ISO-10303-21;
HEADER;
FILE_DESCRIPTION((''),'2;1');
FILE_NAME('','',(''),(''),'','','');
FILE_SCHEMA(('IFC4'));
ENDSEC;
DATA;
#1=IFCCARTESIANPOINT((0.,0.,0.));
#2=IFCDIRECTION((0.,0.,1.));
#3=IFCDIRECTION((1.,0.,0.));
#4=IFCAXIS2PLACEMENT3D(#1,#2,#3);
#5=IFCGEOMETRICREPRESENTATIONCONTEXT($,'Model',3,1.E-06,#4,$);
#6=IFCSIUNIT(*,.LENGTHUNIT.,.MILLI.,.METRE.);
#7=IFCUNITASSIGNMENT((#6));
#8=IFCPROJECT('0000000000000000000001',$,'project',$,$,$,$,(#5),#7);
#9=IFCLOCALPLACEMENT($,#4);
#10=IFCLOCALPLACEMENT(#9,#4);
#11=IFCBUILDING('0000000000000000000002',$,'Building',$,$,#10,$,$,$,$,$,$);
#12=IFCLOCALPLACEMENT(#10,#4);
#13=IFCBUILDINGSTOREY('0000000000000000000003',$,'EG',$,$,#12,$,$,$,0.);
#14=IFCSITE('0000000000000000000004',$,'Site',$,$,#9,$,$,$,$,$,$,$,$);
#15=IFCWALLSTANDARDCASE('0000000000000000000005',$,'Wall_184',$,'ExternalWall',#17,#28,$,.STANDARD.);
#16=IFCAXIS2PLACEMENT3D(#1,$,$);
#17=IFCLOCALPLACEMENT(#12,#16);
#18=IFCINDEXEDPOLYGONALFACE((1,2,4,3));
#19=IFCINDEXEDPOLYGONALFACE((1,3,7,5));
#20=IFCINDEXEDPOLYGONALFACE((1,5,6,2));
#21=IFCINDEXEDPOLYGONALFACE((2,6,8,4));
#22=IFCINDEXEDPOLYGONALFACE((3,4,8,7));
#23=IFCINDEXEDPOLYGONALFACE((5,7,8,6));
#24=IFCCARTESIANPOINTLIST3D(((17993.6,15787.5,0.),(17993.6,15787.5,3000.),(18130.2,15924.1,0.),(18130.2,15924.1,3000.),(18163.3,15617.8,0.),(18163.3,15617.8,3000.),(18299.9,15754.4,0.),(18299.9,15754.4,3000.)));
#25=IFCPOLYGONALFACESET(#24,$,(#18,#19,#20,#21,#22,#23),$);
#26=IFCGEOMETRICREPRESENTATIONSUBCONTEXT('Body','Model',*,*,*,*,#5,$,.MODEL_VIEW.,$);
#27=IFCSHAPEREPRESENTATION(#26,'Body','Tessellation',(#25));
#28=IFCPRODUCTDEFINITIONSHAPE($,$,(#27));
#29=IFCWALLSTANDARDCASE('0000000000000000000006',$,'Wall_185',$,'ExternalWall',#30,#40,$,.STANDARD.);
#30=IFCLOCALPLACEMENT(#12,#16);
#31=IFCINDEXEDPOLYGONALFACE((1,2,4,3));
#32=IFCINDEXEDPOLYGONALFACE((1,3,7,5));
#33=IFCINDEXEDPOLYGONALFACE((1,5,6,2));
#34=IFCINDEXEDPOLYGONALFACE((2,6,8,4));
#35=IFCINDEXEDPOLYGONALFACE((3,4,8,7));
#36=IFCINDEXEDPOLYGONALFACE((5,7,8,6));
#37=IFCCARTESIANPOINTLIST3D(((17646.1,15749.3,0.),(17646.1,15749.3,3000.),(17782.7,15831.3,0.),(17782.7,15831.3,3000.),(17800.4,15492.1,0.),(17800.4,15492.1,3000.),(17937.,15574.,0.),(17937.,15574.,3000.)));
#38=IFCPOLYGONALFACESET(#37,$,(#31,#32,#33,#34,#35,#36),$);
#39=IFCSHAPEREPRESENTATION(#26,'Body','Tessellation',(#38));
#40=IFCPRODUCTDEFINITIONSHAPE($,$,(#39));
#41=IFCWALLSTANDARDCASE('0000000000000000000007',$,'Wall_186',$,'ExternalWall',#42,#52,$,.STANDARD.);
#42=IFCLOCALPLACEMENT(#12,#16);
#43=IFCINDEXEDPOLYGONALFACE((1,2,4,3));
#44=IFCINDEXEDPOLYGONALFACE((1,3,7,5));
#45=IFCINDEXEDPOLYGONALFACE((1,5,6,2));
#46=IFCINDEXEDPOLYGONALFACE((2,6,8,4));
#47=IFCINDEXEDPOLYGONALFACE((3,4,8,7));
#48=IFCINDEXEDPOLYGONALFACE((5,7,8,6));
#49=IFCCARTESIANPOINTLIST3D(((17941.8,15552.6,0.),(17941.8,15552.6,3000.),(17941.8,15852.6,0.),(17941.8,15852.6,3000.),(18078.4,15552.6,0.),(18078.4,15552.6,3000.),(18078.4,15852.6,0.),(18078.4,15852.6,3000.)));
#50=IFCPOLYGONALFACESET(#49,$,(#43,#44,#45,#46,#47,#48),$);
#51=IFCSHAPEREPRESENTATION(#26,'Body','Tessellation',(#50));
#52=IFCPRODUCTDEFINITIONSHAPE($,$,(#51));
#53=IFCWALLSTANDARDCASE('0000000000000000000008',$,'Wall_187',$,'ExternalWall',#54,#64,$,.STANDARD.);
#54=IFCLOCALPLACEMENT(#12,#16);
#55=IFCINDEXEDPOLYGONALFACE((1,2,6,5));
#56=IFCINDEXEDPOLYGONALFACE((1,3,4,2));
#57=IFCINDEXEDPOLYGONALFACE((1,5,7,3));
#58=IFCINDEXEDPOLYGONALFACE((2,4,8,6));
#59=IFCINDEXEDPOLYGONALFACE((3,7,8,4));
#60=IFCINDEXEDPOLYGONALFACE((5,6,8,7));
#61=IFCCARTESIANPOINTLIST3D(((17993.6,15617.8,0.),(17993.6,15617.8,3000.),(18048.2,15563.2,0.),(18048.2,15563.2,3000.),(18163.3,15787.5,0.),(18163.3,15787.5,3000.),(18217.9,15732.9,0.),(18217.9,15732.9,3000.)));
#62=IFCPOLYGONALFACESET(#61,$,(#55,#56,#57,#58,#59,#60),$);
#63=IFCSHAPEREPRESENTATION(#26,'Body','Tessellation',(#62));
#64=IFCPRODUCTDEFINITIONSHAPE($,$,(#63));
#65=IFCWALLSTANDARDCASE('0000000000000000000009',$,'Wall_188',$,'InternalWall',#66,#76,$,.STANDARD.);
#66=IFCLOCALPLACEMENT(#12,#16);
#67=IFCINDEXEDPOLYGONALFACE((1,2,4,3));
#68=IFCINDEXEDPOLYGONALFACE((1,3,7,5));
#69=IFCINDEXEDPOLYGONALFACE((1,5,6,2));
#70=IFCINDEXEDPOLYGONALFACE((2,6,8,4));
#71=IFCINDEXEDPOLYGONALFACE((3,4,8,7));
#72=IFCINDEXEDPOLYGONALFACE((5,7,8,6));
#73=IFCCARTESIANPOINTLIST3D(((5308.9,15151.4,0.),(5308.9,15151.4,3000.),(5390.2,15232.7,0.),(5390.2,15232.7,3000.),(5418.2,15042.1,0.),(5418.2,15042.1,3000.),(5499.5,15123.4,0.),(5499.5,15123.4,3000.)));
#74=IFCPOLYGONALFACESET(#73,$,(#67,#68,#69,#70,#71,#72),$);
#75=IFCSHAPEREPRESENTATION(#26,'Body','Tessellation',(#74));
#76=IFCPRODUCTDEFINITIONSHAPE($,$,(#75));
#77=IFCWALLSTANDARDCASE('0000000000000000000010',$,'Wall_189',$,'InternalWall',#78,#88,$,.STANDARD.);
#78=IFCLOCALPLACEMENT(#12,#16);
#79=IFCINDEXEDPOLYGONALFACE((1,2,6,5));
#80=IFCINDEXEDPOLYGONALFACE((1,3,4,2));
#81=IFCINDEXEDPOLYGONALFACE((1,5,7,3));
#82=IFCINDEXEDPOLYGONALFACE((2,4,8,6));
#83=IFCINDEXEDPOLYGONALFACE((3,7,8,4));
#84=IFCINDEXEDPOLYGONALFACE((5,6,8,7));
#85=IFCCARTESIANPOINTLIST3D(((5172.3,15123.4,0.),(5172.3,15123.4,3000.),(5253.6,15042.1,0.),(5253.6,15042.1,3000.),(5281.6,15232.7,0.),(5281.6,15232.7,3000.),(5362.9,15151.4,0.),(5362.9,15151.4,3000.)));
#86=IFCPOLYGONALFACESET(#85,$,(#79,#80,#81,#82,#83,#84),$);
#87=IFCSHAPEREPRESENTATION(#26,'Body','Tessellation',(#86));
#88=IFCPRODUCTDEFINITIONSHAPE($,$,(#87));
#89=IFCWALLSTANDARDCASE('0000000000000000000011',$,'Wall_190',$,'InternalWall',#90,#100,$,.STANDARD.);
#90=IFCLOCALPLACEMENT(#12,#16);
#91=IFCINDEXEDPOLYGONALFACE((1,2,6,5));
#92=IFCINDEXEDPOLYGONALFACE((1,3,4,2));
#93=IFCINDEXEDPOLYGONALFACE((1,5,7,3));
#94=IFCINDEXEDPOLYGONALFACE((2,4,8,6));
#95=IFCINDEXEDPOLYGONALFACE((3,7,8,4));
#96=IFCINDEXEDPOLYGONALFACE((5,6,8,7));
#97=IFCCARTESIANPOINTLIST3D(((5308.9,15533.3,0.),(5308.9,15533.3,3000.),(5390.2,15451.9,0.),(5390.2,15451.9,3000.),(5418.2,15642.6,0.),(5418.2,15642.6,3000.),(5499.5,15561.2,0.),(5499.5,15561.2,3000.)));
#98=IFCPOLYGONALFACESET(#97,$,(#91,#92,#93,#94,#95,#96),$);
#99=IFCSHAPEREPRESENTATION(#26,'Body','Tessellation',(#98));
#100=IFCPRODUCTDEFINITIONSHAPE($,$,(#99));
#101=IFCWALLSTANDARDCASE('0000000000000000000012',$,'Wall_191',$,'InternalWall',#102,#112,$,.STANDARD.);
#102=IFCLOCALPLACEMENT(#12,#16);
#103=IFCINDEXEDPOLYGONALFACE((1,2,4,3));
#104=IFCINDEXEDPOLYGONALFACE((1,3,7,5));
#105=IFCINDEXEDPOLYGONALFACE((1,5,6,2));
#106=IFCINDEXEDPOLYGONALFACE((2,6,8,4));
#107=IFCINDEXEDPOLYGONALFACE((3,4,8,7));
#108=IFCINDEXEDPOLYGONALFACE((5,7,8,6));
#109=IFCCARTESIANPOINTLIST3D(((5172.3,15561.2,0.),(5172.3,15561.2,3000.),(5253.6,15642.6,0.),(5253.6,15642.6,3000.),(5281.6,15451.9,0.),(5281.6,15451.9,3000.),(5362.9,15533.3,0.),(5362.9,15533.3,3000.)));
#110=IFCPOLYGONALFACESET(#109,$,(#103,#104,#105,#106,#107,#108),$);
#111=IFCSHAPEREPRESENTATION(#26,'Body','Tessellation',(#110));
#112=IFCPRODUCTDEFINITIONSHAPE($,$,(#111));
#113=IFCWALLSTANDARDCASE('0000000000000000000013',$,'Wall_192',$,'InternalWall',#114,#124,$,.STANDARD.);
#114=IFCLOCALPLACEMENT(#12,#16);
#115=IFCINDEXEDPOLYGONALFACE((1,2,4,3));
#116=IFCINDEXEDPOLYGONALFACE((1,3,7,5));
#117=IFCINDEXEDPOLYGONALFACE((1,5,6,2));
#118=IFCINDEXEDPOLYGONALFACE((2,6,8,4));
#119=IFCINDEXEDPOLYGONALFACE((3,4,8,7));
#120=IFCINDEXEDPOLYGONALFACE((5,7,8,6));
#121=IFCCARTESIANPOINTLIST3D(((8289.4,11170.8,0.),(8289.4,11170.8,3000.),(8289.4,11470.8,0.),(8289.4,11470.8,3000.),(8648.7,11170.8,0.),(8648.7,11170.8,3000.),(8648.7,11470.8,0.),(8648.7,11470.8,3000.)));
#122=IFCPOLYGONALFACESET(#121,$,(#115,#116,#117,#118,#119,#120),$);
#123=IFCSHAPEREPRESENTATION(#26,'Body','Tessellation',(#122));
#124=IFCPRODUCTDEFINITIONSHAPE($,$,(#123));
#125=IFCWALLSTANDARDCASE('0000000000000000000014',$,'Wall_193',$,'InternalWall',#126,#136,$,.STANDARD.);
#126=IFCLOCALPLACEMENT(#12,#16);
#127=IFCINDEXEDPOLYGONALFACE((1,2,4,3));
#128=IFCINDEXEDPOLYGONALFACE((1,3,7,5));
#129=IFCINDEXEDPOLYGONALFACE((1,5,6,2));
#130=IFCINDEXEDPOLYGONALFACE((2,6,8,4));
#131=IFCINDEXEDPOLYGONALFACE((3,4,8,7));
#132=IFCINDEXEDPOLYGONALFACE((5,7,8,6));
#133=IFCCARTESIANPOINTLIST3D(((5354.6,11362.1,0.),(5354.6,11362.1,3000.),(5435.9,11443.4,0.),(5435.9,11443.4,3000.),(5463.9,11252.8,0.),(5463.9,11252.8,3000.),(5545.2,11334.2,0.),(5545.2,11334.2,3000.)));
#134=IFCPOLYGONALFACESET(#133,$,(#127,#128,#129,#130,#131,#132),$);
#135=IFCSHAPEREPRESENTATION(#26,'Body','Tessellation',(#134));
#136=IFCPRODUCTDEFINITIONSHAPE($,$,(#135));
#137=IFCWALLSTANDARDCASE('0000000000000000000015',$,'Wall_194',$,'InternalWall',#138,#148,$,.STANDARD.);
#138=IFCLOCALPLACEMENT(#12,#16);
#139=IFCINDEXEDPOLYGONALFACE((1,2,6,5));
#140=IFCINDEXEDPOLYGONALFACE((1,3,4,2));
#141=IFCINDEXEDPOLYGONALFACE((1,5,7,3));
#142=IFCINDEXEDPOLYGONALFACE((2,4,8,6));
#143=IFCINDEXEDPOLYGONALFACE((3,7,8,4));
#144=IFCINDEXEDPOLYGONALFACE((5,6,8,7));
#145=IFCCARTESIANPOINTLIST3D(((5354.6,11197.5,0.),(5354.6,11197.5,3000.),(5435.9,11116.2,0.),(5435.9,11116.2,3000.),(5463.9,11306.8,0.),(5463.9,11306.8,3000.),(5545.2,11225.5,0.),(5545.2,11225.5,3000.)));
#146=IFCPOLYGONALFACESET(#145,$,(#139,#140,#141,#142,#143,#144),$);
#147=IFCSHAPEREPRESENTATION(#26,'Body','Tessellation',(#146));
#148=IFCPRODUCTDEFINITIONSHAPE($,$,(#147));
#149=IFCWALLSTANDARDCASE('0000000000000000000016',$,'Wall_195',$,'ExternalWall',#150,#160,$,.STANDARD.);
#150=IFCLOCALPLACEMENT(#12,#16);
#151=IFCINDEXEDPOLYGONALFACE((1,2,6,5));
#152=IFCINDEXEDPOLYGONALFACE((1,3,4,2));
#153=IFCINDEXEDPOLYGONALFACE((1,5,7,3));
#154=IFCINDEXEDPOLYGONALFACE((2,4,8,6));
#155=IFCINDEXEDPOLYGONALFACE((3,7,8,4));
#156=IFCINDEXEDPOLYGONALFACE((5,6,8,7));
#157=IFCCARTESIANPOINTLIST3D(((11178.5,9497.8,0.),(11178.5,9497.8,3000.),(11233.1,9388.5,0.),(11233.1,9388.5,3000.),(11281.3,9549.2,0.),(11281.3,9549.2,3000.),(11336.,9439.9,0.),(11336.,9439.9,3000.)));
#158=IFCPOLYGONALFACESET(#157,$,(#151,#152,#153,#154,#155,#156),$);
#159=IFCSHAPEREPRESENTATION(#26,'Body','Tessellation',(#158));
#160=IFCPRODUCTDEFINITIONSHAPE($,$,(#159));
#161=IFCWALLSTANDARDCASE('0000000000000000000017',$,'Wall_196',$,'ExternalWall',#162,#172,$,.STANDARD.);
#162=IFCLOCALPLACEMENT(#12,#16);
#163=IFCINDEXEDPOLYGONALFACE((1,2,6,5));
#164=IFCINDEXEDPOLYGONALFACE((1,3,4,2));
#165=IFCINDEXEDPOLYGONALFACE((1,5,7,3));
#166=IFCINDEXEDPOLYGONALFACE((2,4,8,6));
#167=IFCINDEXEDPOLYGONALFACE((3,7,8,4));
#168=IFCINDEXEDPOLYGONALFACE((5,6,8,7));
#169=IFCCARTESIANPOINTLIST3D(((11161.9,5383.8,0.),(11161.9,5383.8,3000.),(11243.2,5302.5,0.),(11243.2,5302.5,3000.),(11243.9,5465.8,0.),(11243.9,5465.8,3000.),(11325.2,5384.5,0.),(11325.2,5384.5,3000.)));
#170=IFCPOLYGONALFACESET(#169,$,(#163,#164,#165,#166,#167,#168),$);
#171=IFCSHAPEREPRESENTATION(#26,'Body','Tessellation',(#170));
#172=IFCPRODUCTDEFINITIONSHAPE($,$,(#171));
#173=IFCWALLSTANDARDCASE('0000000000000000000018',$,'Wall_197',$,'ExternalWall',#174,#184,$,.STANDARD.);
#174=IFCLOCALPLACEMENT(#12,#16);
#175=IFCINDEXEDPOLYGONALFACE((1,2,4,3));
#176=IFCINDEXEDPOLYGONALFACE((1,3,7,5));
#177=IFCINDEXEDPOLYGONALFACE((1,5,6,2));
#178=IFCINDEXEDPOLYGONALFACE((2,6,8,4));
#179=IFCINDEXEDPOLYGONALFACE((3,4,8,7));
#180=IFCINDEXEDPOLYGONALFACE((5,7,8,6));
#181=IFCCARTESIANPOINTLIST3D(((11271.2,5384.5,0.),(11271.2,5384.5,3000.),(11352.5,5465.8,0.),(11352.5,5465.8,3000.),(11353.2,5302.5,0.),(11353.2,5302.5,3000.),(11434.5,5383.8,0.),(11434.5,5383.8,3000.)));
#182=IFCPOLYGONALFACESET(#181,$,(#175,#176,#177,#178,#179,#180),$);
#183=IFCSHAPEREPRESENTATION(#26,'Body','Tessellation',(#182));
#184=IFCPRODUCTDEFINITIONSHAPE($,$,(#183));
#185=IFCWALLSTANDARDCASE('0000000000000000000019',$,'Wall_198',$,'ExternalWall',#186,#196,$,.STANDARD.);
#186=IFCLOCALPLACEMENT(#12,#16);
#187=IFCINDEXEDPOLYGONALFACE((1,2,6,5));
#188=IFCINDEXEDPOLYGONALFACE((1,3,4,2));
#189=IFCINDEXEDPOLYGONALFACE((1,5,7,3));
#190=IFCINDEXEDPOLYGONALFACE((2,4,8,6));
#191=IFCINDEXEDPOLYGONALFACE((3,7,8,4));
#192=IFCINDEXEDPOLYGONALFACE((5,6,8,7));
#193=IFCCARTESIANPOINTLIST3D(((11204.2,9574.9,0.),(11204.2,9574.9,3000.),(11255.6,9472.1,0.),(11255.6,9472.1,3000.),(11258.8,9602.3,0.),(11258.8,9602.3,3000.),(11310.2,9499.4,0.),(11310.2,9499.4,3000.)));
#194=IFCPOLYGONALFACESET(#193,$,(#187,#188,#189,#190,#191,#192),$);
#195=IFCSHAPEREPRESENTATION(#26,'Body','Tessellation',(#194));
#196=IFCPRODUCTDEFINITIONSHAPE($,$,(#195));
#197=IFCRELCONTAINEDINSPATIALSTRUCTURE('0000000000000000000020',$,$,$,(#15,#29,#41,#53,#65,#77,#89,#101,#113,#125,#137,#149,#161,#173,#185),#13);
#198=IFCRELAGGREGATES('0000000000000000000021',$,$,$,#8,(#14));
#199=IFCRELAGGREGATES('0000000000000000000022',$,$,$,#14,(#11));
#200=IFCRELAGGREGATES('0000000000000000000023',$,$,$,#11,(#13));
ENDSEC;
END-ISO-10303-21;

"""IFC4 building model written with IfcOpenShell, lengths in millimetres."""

from ifc_helpers import new_model, si_unit, frame, origin_with_axes, place, context, subcontext, project, spatial, rectangle, extrude, element, save


model = new_model("IFC4")

# Units and contexts
model_context = context("Model", 3, precision=1e-06, world=origin_with_axes())
body_context = subcontext(model_context, "Body", "Model", "MODEL_VIEW")
ifc_project = project(units=[si_unit("LENGTHUNIT", "METRE", prefix="MILLI")], contexts=[model_context])

# Site, building, storey
site_placement = place(None, origin_with_axes())
site = spatial("IfcSite", under=ifc_project, at=site_placement, Name="Site")
building_placement = place(site_placement, origin_with_axes())
building = spatial("IfcBuilding", under=site, at=building_placement, Name="Building")
storey_placement = place(building_placement, origin_with_axes())
storey = spatial("IfcBuildingStorey", under=building, at=storey_placement, Name="EG", Elevation=0.0)

# Walls
wall_1_placement = place(storey_placement, origin_with_axes())
element("IfcWallStandardCase", 1, at=wall_1_placement, inside=storey, Name="Wall_184", ObjectType="ExternalWall", PredefinedType="STANDARD", context=body_context, shape_type="SweptSolid", body=[
    extrude(rectangle(XDim=193.2, YDim=240.0), frame((18146.7, 15771.0, 0.0), z_axis=(0.0, 0.0, 1.0), x_axis=(0.707107, 0.707107, 0.0)), (0.0, 0.0, 1.0), 3000.0),
])
wall_2_placement = place(storey_placement, origin_with_axes())
element("IfcWallStandardCase", 2, at=wall_2_placement, inside=storey, Name="Wall_185", ObjectType="ExternalWall", PredefinedType="STANDARD", context=body_context, shape_type="SweptSolid", body=[
    extrude(rectangle(XDim=159.3, YDim=300.0), frame((17791.5, 15661.7, 0.0), z_axis=(0.0, 0.0, 1.0), x_axis=(0.857493, 0.514496, 0.0)), (0.0, 0.0, 1.0), 3000.0),
])
wall_3_placement = place(storey_placement, origin_with_axes())
element("IfcWallStandardCase", 3, at=wall_3_placement, inside=storey, Name="Wall_186", ObjectType="ExternalWall", PredefinedType="STANDARD", context=body_context, shape_type="SweptSolid", body=[
    extrude(rectangle(XDim=136.6, YDim=300.0), frame((18010.1, 15702.6, 0.0), z_axis=(0.0, 0.0, 1.0), x_axis=(1.0, 0.0, 0.0)), (0.0, 0.0, 1.0), 3000.0),
])
wall_4_placement = place(storey_placement, origin_with_axes())
element("IfcWallStandardCase", 4, at=wall_4_placement, inside=storey, Name="Wall_187", ObjectType="ExternalWall", PredefinedType="STANDARD", context=body_context, shape_type="SweptSolid", body=[
    extrude(rectangle(XDim=77.3, YDim=240.0), frame((18105.7, 15675.3, 0.0), z_axis=(0.0, 0.0, 1.0), x_axis=(0.707107, -0.707107, 0.0)), (0.0, 0.0, 1.0), 3000.0),
])
wall_5_placement = place(storey_placement, origin_with_axes())
element("IfcWallStandardCase", 5, at=wall_5_placement, inside=storey, Name="Wall_188", ObjectType="InternalWall", PredefinedType="STANDARD", context=body_context, shape_type="SweptSolid", body=[
    extrude(rectangle(XDim=154.6, YDim=115.0), frame((5404.2, 15137.4, 0.0), z_axis=(0.0, 0.0, 1.0), x_axis=(0.707107, -0.707107, 0.0)), (0.0, 0.0, 1.0), 3000.0),
])
wall_6_placement = place(storey_placement, origin_with_axes())
element("IfcWallStandardCase", 6, at=wall_6_placement, inside=storey, Name="Wall_189", ObjectType="InternalWall", PredefinedType="STANDARD", context=body_context, shape_type="SweptSolid", body=[
    extrude(rectangle(XDim=154.6, YDim=115.0), frame((5267.6, 15137.4, 0.0), z_axis=(0.0, 0.0, 1.0), x_axis=(-0.707107, -0.707107, 0.0)), (0.0, 0.0, 1.0), 3000.0),
])
wall_7_placement = place(storey_placement, origin_with_axes())
element("IfcWallStandardCase", 7, at=wall_7_placement, inside=storey, Name="Wall_190", ObjectType="InternalWall", PredefinedType="STANDARD", context=body_context, shape_type="SweptSolid", body=[
    extrude(rectangle(XDim=154.6, YDim=115.0), frame((5404.2, 15547.3, 0.0), z_axis=(0.0, 0.0, 1.0), x_axis=(0.707107, 0.707107, 0.0)), (0.0, 0.0, 1.0), 3000.0),
])
wall_8_placement = place(storey_placement, origin_with_axes())
element("IfcWallStandardCase", 8, at=wall_8_placement, inside=storey, Name="Wall_191", ObjectType="InternalWall", PredefinedType="STANDARD", context=body_context, shape_type="SweptSolid", body=[
    extrude(rectangle(XDim=154.6, YDim=115.0), frame((5267.6, 15547.3, 0.0), z_axis=(0.0, 0.0, 1.0), x_axis=(-0.707107, 0.707107, 0.0)), (0.0, 0.0, 1.0), 3000.0),
])
wall_9_placement = place(storey_placement, origin_with_axes())
element("IfcWallStandardCase", 9, at=wall_9_placement, inside=storey, Name="Wall_192", ObjectType="InternalWall", PredefinedType="STANDARD", context=body_context, shape_type="SweptSolid", body=[
    extrude(rectangle(XDim=359.4, YDim=300.0), frame((8469.0, 11320.8, 0.0), z_axis=(0.0, 0.0, 1.0), x_axis=(1.0, 0.0, 0.0)), (0.0, 0.0, 1.0), 3000.0),
])
wall_10_placement = place(storey_placement, origin_with_axes())
element("IfcWallStandardCase", 10, at=wall_10_placement, inside=storey, Name="Wall_193", ObjectType="InternalWall", PredefinedType="STANDARD", context=body_context, shape_type="SweptSolid", body=[
    extrude(rectangle(XDim=154.6, YDim=115.0), frame((5449.9, 11348.1, 0.0), z_axis=(0.0, 0.0, 1.0), x_axis=(-0.707107, 0.707107, 0.0)), (0.0, 0.0, 1.0), 3000.0),
])
wall_11_placement = place(storey_placement, origin_with_axes())
element("IfcWallStandardCase", 11, at=wall_11_placement, inside=storey, Name="Wall_194", ObjectType="InternalWall", PredefinedType="STANDARD", context=body_context, shape_type="SweptSolid", body=[
    extrude(rectangle(XDim=154.6, YDim=115.0), frame((5449.9, 11211.5, 0.0), z_axis=(0.0, 0.0, 1.0), x_axis=(-0.707107, -0.707107, 0.0)), (0.0, 0.0, 1.0), 3000.0),
])
wall_12_placement = place(storey_placement, origin_with_axes())
element("IfcWallStandardCase", 12, at=wall_12_placement, inside=storey, Name="Wall_195", ObjectType="ExternalWall", PredefinedType="STANDARD", context=body_context, shape_type="SweptSolid", body=[
    extrude(rectangle(XDim=122.2, YDim=115.0), frame((11257.2, 9468.9, 0.0), z_axis=(0.0, 0.0, 1.0), x_axis=(-0.447214, 0.894427, 0.0)), (0.0, 0.0, 1.0), 3000.0),
])
wall_13_placement = place(storey_placement, origin_with_axes())
element("IfcWallStandardCase", 13, at=wall_13_placement, inside=storey, Name="Wall_196", ObjectType="ExternalWall", PredefinedType="STANDARD", context=body_context, shape_type="SweptSolid", body=[
    extrude(rectangle(XDim=115.9, YDim=115.0), frame((11243.5, 5384.2, 0.0), z_axis=(0.0, 0.0, 1.0), x_axis=(-0.707107, -0.707107, 0.0)), (0.0, 0.0, 1.0), 3000.0),
])
wall_14_placement = place(storey_placement, origin_with_axes())
element("IfcWallStandardCase", 14, at=wall_14_placement, inside=storey, Name="Wall_197", ObjectType="ExternalWall", PredefinedType="STANDARD", context=body_context, shape_type="SweptSolid", body=[
    extrude(rectangle(XDim=115.9, YDim=115.0), frame((11352.8, 5384.2, 0.0), z_axis=(0.0, 0.0, 1.0), x_axis=(0.707107, -0.707107, 0.0)), (0.0, 0.0, 1.0), 3000.0),
])
wall_15_placement = place(storey_placement, origin_with_axes())
element("IfcWallStandardCase", 15, at=wall_15_placement, inside=storey, Name="Wall_198", ObjectType="ExternalWall", PredefinedType="STANDARD", context=body_context, shape_type="SweptSolid", body=[
    extrude(rectangle(XDim=61.1, YDim=115.0), frame((11257.2, 9537.2, 0.0), z_axis=(0.0, 0.0, 1.0), x_axis=(0.894427, 0.447214, 0.0)), (0.0, 0.0, 1.0), 3000.0),
])

save(model, "model.ifc")
